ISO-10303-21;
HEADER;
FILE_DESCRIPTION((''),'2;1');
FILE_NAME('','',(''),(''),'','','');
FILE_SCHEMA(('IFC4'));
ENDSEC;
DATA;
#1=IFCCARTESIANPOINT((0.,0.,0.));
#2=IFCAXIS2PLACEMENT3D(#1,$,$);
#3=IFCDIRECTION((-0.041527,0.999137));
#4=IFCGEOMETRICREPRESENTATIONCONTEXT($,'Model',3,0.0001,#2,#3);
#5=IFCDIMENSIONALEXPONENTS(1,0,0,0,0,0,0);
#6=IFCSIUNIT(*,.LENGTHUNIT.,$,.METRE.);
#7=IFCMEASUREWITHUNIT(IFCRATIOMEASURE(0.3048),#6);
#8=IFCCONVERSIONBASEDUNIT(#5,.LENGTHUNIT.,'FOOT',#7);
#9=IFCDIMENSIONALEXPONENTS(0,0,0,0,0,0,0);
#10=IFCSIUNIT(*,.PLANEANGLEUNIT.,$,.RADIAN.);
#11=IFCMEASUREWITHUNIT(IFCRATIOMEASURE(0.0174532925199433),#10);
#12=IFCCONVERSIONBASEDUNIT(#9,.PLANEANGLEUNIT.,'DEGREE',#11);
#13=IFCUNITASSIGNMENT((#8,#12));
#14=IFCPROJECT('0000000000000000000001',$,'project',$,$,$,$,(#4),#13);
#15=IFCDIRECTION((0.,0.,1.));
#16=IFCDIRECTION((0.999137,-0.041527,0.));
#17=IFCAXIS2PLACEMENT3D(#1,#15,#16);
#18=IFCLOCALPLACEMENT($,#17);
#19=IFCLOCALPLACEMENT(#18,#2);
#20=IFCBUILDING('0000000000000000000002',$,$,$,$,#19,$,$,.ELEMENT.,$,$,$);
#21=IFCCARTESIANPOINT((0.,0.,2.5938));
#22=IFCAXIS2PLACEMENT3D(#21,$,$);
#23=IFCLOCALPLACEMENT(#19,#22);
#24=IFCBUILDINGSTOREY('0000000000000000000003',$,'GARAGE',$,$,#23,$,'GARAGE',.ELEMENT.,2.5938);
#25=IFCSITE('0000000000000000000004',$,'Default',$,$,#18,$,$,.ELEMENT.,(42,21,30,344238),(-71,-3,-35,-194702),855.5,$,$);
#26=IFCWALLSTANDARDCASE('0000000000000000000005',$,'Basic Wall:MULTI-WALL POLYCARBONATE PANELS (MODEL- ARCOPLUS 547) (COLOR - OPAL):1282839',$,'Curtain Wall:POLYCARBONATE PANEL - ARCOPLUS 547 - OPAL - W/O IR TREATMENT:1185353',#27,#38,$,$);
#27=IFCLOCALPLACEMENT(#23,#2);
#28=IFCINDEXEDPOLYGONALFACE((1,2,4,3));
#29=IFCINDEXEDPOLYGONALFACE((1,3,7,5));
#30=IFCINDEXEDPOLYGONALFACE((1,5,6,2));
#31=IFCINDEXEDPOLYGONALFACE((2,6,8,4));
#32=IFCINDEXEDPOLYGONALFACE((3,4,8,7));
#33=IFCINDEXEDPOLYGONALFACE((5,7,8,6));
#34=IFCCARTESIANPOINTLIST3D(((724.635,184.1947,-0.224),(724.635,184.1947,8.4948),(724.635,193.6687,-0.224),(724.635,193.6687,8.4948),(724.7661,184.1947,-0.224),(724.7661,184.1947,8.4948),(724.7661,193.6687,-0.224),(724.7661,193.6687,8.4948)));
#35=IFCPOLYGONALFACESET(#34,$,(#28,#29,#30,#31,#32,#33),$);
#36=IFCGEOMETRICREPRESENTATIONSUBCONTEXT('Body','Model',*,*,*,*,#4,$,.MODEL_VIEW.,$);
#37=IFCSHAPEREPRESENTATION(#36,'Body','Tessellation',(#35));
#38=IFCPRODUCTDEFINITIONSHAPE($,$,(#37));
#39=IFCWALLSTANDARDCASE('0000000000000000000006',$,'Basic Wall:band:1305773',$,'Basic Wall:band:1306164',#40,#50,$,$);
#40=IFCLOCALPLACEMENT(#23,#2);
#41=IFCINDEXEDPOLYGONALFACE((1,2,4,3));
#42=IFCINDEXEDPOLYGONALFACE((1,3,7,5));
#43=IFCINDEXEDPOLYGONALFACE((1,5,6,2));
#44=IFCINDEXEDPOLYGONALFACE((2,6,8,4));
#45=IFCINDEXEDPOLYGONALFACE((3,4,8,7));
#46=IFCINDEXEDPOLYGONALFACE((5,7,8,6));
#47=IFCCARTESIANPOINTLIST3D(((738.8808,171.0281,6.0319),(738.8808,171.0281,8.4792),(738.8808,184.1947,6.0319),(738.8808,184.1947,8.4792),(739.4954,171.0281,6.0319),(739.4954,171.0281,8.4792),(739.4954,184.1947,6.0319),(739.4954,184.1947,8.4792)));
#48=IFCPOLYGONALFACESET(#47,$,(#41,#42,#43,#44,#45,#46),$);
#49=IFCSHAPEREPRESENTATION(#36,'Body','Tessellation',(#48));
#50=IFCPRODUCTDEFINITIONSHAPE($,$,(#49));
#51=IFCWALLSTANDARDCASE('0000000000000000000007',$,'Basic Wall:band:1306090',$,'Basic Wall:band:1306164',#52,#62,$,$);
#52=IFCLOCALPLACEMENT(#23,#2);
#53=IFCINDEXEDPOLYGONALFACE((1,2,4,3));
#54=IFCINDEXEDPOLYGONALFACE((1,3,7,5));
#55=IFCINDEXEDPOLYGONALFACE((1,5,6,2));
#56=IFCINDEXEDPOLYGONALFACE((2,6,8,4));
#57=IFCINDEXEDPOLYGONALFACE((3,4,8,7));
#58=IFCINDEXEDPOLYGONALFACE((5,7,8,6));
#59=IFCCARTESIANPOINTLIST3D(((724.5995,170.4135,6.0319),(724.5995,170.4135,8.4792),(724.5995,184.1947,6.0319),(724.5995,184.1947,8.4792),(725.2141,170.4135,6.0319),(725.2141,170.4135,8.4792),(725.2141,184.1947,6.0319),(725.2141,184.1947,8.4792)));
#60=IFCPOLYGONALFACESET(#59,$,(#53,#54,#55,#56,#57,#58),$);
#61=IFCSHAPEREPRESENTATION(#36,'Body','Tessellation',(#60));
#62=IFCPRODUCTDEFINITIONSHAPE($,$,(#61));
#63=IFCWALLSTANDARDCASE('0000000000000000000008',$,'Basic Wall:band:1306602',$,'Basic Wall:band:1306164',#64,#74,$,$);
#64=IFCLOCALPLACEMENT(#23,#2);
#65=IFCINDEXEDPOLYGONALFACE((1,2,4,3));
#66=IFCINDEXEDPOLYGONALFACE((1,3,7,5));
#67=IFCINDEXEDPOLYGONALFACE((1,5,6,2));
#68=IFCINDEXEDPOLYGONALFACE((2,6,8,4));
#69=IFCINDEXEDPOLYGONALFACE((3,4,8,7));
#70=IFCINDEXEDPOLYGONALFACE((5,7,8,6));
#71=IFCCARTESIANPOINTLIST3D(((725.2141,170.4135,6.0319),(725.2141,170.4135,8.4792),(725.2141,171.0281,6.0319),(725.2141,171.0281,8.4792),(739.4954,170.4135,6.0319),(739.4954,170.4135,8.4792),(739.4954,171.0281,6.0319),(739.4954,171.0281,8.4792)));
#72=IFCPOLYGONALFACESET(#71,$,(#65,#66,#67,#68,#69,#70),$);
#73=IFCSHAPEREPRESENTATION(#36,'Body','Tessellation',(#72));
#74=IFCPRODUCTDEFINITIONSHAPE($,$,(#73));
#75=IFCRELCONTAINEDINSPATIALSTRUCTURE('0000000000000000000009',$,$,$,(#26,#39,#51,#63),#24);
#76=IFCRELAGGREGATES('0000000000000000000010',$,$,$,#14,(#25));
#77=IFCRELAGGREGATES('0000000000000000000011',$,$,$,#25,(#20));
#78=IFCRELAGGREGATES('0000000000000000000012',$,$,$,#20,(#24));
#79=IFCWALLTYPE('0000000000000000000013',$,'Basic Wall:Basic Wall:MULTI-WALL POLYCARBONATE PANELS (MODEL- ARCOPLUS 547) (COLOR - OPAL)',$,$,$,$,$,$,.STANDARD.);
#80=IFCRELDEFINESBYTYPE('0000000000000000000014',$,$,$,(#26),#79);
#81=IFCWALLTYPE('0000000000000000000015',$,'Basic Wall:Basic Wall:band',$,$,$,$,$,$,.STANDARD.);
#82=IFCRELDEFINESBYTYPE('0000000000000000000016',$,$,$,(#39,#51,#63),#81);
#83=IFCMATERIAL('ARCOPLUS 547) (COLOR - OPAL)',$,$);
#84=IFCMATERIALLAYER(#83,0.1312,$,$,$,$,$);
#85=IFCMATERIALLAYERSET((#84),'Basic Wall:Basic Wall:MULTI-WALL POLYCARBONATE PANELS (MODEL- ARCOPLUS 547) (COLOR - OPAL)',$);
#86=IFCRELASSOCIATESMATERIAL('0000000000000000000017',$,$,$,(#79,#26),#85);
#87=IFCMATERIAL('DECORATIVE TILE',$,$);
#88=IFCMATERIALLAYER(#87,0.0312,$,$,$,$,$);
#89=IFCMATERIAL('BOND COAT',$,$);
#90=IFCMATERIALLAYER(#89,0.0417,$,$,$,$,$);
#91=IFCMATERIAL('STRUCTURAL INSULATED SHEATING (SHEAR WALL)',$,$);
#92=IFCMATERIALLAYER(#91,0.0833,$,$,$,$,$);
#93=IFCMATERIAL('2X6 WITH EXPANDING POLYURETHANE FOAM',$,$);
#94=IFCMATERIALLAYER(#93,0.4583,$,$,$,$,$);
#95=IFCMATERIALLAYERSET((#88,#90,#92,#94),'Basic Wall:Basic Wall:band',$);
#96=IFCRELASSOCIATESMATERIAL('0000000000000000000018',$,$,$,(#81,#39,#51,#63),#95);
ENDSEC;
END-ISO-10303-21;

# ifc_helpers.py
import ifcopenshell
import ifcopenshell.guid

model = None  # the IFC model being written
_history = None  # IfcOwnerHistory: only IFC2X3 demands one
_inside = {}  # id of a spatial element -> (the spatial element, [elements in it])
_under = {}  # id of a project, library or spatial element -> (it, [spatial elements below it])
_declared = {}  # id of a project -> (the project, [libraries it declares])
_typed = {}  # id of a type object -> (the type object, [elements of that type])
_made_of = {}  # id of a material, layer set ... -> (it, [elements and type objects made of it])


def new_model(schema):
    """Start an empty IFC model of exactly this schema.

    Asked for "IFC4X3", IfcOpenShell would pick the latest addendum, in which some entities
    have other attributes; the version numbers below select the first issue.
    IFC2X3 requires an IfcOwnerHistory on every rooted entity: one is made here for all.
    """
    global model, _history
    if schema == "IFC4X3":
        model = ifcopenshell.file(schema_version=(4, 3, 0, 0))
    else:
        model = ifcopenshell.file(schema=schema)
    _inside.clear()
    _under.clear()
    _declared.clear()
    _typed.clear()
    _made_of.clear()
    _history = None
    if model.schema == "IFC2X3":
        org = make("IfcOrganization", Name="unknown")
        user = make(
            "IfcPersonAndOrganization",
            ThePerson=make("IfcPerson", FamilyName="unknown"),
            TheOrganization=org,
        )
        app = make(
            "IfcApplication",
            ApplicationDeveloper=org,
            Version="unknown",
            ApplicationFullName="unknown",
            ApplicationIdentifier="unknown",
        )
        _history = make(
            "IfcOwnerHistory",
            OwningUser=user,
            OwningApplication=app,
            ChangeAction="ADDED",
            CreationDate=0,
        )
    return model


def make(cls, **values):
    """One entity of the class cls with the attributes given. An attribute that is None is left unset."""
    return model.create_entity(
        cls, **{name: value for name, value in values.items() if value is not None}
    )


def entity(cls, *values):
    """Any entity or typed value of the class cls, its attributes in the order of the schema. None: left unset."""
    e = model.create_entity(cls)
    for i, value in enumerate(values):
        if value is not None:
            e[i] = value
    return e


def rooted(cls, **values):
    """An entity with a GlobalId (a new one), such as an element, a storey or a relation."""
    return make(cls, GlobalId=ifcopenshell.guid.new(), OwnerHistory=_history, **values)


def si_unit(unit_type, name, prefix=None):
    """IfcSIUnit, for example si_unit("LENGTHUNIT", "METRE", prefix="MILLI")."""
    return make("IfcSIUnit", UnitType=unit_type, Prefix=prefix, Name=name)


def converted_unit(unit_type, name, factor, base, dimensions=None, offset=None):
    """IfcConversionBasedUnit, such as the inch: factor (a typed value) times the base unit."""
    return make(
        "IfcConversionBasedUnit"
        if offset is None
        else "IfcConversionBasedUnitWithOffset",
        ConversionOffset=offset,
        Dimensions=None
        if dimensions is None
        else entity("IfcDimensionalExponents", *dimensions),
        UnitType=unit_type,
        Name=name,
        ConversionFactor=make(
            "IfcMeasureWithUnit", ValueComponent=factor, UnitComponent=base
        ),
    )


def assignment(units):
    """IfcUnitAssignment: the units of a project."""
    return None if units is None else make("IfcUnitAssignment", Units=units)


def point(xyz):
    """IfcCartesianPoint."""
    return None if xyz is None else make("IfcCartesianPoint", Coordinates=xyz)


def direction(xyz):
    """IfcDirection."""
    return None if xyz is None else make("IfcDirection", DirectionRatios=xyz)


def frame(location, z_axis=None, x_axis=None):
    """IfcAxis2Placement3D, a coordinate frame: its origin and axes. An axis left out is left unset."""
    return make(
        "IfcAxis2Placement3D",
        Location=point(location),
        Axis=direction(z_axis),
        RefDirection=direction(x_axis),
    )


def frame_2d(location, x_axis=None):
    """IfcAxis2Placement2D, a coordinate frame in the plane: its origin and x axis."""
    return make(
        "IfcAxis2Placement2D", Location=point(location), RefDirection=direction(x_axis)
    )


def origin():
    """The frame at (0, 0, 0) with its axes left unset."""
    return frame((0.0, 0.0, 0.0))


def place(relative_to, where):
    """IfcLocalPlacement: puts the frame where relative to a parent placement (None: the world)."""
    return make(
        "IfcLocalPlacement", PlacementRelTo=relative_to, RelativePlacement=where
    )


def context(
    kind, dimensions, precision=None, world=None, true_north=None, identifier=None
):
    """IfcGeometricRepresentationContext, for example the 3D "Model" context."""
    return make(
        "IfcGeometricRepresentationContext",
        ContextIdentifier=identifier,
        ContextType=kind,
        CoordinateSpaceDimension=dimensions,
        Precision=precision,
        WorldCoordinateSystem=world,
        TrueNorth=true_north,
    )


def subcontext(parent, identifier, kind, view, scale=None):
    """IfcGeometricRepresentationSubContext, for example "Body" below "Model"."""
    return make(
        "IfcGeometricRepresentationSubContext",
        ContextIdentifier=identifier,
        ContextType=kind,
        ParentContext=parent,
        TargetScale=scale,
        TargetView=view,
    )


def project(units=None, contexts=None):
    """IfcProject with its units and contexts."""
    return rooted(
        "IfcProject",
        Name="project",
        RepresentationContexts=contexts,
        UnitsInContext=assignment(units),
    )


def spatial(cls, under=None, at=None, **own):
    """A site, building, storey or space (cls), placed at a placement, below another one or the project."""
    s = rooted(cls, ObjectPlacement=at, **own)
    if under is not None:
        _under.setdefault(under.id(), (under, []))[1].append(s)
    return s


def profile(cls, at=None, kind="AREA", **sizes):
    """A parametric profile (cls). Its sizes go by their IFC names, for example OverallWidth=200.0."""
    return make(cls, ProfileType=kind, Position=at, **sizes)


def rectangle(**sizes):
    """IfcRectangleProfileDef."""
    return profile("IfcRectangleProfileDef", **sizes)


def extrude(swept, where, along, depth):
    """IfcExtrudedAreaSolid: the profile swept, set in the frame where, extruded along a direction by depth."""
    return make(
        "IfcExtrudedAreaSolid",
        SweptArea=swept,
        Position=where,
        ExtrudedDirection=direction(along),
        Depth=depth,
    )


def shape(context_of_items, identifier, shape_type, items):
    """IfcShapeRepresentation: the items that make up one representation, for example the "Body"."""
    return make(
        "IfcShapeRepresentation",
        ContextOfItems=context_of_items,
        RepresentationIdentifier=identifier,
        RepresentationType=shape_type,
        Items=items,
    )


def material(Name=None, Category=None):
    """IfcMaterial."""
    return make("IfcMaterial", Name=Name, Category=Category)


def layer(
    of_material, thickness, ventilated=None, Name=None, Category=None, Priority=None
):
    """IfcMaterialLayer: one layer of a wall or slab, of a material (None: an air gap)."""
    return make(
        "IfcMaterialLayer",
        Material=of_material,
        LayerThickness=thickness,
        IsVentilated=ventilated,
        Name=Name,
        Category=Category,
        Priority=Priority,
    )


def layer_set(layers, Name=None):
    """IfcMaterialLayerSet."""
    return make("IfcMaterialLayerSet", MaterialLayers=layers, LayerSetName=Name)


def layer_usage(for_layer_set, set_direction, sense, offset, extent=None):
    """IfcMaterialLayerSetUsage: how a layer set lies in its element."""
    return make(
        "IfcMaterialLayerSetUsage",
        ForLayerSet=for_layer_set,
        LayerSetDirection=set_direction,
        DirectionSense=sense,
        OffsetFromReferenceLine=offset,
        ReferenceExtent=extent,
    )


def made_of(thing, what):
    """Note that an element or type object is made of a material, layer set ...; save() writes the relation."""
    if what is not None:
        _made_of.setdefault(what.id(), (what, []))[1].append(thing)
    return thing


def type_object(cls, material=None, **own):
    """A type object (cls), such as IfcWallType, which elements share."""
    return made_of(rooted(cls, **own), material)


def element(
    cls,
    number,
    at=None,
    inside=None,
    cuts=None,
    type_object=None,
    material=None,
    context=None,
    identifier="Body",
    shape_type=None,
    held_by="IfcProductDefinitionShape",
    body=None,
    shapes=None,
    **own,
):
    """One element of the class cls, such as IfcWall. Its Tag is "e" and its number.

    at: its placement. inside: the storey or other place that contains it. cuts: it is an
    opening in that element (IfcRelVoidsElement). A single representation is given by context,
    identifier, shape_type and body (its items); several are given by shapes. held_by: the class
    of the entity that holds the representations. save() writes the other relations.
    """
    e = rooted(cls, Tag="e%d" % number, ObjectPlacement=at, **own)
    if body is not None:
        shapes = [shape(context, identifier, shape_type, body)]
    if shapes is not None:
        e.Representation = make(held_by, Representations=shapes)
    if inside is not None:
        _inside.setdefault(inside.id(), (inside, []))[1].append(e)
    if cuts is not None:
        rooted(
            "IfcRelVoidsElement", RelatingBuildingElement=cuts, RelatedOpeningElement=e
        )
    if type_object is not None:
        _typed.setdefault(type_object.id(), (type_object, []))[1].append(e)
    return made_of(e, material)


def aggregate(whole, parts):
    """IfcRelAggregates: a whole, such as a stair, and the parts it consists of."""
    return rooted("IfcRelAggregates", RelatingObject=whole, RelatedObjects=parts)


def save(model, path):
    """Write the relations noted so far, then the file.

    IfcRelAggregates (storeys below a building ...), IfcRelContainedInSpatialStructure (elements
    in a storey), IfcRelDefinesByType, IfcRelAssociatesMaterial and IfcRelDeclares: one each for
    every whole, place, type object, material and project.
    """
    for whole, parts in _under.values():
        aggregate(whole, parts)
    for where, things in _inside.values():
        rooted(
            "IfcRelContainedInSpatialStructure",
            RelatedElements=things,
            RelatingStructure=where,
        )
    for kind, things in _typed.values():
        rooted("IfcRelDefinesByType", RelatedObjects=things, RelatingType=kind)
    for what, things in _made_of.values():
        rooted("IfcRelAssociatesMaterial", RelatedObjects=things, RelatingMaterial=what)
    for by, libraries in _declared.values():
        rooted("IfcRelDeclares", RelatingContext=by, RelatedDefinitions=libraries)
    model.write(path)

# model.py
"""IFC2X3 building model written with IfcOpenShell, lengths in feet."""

from ifc_helpers import new_model, entity, si_unit, converted_unit, direction, frame, frame_2d, origin, place, context, subcontext, project, spatial, rectangle, extrude, material, layer, layer_set, layer_usage, type_object, element, save


model = new_model("IFC2X3")

# Units and contexts
model_context = context("Model", 3, precision=0.0001, world=origin(), true_north=direction((-0.041527, 0.999137)))
body_context = subcontext(model_context, "Body", "Model", "MODEL_VIEW")
ifc_project = project(units=[converted_unit("LENGTHUNIT", "FOOT", entity("IfcRatioMeasure", 0.3048), si_unit("LENGTHUNIT", "METRE"), dimensions=[1, 0, 0, 0, 0, 0, 0]), converted_unit("PLANEANGLEUNIT", "DEGREE", entity("IfcRatioMeasure", 0.0174532925199433), si_unit("PLANEANGLEUNIT", "RADIAN"), dimensions=[0, 0, 0, 0, 0, 0, 0])], contexts=[model_context])

# Site, building, storey
site_placement = place(None, frame((0.0, 0.0, 0.0), z_axis=(0.0, 0.0, 1.0), x_axis=(0.999137, -0.041527, 0.0)))
site = spatial("IfcSite", under=ifc_project, at=site_placement, Name="Default", CompositionType="ELEMENT", RefLatitude=(42, 21, 30, 344238), RefLongitude=(-71, -3, -35, -194702), RefElevation=855.5)
building_placement = place(site_placement, origin())
building = spatial("IfcBuilding", under=site, at=building_placement, CompositionType="ELEMENT")
storey_placement = place(building_placement, frame((0.0, 0.0, 2.5938)))
storey = spatial("IfcBuildingStorey", under=building, at=storey_placement, Name="GARAGE", LongName="GARAGE", CompositionType="ELEMENT", Elevation=2.5938)

# Walls
ifc_material_1 = material(Name="ARCOPLUS 547) (COLOR - OPAL)")
ifc_layer_1 = layer(ifc_material_1, 0.1312)
ifc_layer_set_1 = layer_set([ifc_layer_1], Name="Basic Wall:Basic Wall:MULTI-WALL POLYCARBONATE PANELS (MODEL- ARCOPLUS 547) (COLOR - OPAL)")
ifc_layer_usage_1 = layer_usage(ifc_layer_set_1, "AXIS2", "NEGATIVE", 0.0656)
wall_type_1 = type_object("IfcWallType", Name="Basic Wall:Basic Wall:MULTI-WALL POLYCARBONATE PANELS (MODEL- ARCOPLUS 547) (COLOR - OPAL)", PredefinedType="STANDARD", material=ifc_layer_set_1)
wall_1_placement = place(storey_placement, frame((724.7006, 184.1947, -0.224), z_axis=(0.0, 0.0, 1.0), x_axis=(0.0, 1.0, 0.0)))
element("IfcWallStandardCase", 1, at=wall_1_placement, inside=storey, type_object=wall_type_1, material=ifc_layer_usage_1, Name="Basic Wall:MULTI-WALL POLYCARBONATE PANELS (MODEL- ARCOPLUS 547) (COLOR - OPAL):1282839", ObjectType="Curtain Wall:POLYCARBONATE PANEL - ARCOPLUS 547 - OPAL - W/O IR TREATMENT:1185353", context=body_context, shape_type="SweptSolid", body=[
    extrude(rectangle(XDim=9.474, YDim=0.1312, at=frame_2d((4.737, 0.0), x_axis=(-1.0, 0.0))), origin(), (0.0, 0.0, 1.0), 8.7187),
])
ifc_material_2 = material(Name="DECORATIVE TILE")
ifc_layer_2 = layer(ifc_material_2, 0.0312)
ifc_material_3 = material(Name="BOND COAT")
ifc_layer_3 = layer(ifc_material_3, 0.0417)
ifc_material_4 = material(Name="STRUCTURAL INSULATED SHEATING (SHEAR WALL)")
ifc_layer_4 = layer(ifc_material_4, 0.0833)
ifc_material_5 = material(Name="2X6 WITH EXPANDING POLYURETHANE FOAM")
ifc_layer_5 = layer(ifc_material_5, 0.4583)
ifc_layer_set_2 = layer_set([ifc_layer_2, ifc_layer_3, ifc_layer_4, ifc_layer_5], Name="Basic Wall:Basic Wall:band")
ifc_layer_usage_2 = layer_usage(ifc_layer_set_2, "AXIS2", "NEGATIVE", 0.3073)
wall_type_2 = type_object("IfcWallType", Name="Basic Wall:Basic Wall:band", PredefinedType="STANDARD", material=ifc_layer_set_2)
wall_2_placement = place(storey_placement, frame((739.1881, 184.1947, 6.0319), z_axis=(0.0, 0.0, 1.0), x_axis=(0.0, -1.0, 0.0)))
element("IfcWallStandardCase", 2, at=wall_2_placement, inside=storey, type_object=wall_type_2, material=ifc_layer_usage_2, Name="Basic Wall:band:1305773", ObjectType="Basic Wall:band:1306164", context=body_context, shape_type="SweptSolid", body=[
    extrude(rectangle(XDim=13.1667, YDim=0.6146, at=frame_2d((6.5833, 0.0), x_axis=(-1.0, 0.0))), origin(), (0.0, 0.0, 1.0), 2.4473),
])
ifc_layer_usage_3 = layer_usage(ifc_layer_set_2, "AXIS2", "NEGATIVE", 0.3073)
wall_3_placement = place(storey_placement, frame((724.9068, 170.4135, 6.0319), z_axis=(0.0, 0.0, 1.0), x_axis=(0.0, 1.0, 0.0)))
element("IfcWallStandardCase", 3, at=wall_3_placement, inside=storey, type_object=wall_type_2, material=ifc_layer_usage_3, Name="Basic Wall:band:1306090", ObjectType="Basic Wall:band:1306164", context=body_context, shape_type="SweptSolid", body=[
    extrude(rectangle(XDim=13.7813, YDim=0.6146, at=frame_2d((6.8906, 0.0), x_axis=(-1.0, 0.0))), origin(), (0.0, 0.0, 1.0), 2.4473),
])
ifc_layer_usage_4 = layer_usage(ifc_layer_set_2, "AXIS2", "NEGATIVE", 0.3073)
wall_4_placement = place(storey_placement, frame((739.4954, 170.7208, 6.0319), z_axis=(0.0, 0.0, 1.0), x_axis=(-1.0, 0.0, 0.0)))
element("IfcWallStandardCase", 4, at=wall_4_placement, inside=storey, type_object=wall_type_2, material=ifc_layer_usage_4, Name="Basic Wall:band:1306602", ObjectType="Basic Wall:band:1306164", context=body_context, shape_type="SweptSolid", body=[
    extrude(rectangle(XDim=14.2813, YDim=0.6146, at=frame_2d((7.1406, 0.0), x_axis=(-1.0, 0.0))), origin(), (0.0, 0.0, 1.0), 2.4473),
])

save(model, "model.ifc")
